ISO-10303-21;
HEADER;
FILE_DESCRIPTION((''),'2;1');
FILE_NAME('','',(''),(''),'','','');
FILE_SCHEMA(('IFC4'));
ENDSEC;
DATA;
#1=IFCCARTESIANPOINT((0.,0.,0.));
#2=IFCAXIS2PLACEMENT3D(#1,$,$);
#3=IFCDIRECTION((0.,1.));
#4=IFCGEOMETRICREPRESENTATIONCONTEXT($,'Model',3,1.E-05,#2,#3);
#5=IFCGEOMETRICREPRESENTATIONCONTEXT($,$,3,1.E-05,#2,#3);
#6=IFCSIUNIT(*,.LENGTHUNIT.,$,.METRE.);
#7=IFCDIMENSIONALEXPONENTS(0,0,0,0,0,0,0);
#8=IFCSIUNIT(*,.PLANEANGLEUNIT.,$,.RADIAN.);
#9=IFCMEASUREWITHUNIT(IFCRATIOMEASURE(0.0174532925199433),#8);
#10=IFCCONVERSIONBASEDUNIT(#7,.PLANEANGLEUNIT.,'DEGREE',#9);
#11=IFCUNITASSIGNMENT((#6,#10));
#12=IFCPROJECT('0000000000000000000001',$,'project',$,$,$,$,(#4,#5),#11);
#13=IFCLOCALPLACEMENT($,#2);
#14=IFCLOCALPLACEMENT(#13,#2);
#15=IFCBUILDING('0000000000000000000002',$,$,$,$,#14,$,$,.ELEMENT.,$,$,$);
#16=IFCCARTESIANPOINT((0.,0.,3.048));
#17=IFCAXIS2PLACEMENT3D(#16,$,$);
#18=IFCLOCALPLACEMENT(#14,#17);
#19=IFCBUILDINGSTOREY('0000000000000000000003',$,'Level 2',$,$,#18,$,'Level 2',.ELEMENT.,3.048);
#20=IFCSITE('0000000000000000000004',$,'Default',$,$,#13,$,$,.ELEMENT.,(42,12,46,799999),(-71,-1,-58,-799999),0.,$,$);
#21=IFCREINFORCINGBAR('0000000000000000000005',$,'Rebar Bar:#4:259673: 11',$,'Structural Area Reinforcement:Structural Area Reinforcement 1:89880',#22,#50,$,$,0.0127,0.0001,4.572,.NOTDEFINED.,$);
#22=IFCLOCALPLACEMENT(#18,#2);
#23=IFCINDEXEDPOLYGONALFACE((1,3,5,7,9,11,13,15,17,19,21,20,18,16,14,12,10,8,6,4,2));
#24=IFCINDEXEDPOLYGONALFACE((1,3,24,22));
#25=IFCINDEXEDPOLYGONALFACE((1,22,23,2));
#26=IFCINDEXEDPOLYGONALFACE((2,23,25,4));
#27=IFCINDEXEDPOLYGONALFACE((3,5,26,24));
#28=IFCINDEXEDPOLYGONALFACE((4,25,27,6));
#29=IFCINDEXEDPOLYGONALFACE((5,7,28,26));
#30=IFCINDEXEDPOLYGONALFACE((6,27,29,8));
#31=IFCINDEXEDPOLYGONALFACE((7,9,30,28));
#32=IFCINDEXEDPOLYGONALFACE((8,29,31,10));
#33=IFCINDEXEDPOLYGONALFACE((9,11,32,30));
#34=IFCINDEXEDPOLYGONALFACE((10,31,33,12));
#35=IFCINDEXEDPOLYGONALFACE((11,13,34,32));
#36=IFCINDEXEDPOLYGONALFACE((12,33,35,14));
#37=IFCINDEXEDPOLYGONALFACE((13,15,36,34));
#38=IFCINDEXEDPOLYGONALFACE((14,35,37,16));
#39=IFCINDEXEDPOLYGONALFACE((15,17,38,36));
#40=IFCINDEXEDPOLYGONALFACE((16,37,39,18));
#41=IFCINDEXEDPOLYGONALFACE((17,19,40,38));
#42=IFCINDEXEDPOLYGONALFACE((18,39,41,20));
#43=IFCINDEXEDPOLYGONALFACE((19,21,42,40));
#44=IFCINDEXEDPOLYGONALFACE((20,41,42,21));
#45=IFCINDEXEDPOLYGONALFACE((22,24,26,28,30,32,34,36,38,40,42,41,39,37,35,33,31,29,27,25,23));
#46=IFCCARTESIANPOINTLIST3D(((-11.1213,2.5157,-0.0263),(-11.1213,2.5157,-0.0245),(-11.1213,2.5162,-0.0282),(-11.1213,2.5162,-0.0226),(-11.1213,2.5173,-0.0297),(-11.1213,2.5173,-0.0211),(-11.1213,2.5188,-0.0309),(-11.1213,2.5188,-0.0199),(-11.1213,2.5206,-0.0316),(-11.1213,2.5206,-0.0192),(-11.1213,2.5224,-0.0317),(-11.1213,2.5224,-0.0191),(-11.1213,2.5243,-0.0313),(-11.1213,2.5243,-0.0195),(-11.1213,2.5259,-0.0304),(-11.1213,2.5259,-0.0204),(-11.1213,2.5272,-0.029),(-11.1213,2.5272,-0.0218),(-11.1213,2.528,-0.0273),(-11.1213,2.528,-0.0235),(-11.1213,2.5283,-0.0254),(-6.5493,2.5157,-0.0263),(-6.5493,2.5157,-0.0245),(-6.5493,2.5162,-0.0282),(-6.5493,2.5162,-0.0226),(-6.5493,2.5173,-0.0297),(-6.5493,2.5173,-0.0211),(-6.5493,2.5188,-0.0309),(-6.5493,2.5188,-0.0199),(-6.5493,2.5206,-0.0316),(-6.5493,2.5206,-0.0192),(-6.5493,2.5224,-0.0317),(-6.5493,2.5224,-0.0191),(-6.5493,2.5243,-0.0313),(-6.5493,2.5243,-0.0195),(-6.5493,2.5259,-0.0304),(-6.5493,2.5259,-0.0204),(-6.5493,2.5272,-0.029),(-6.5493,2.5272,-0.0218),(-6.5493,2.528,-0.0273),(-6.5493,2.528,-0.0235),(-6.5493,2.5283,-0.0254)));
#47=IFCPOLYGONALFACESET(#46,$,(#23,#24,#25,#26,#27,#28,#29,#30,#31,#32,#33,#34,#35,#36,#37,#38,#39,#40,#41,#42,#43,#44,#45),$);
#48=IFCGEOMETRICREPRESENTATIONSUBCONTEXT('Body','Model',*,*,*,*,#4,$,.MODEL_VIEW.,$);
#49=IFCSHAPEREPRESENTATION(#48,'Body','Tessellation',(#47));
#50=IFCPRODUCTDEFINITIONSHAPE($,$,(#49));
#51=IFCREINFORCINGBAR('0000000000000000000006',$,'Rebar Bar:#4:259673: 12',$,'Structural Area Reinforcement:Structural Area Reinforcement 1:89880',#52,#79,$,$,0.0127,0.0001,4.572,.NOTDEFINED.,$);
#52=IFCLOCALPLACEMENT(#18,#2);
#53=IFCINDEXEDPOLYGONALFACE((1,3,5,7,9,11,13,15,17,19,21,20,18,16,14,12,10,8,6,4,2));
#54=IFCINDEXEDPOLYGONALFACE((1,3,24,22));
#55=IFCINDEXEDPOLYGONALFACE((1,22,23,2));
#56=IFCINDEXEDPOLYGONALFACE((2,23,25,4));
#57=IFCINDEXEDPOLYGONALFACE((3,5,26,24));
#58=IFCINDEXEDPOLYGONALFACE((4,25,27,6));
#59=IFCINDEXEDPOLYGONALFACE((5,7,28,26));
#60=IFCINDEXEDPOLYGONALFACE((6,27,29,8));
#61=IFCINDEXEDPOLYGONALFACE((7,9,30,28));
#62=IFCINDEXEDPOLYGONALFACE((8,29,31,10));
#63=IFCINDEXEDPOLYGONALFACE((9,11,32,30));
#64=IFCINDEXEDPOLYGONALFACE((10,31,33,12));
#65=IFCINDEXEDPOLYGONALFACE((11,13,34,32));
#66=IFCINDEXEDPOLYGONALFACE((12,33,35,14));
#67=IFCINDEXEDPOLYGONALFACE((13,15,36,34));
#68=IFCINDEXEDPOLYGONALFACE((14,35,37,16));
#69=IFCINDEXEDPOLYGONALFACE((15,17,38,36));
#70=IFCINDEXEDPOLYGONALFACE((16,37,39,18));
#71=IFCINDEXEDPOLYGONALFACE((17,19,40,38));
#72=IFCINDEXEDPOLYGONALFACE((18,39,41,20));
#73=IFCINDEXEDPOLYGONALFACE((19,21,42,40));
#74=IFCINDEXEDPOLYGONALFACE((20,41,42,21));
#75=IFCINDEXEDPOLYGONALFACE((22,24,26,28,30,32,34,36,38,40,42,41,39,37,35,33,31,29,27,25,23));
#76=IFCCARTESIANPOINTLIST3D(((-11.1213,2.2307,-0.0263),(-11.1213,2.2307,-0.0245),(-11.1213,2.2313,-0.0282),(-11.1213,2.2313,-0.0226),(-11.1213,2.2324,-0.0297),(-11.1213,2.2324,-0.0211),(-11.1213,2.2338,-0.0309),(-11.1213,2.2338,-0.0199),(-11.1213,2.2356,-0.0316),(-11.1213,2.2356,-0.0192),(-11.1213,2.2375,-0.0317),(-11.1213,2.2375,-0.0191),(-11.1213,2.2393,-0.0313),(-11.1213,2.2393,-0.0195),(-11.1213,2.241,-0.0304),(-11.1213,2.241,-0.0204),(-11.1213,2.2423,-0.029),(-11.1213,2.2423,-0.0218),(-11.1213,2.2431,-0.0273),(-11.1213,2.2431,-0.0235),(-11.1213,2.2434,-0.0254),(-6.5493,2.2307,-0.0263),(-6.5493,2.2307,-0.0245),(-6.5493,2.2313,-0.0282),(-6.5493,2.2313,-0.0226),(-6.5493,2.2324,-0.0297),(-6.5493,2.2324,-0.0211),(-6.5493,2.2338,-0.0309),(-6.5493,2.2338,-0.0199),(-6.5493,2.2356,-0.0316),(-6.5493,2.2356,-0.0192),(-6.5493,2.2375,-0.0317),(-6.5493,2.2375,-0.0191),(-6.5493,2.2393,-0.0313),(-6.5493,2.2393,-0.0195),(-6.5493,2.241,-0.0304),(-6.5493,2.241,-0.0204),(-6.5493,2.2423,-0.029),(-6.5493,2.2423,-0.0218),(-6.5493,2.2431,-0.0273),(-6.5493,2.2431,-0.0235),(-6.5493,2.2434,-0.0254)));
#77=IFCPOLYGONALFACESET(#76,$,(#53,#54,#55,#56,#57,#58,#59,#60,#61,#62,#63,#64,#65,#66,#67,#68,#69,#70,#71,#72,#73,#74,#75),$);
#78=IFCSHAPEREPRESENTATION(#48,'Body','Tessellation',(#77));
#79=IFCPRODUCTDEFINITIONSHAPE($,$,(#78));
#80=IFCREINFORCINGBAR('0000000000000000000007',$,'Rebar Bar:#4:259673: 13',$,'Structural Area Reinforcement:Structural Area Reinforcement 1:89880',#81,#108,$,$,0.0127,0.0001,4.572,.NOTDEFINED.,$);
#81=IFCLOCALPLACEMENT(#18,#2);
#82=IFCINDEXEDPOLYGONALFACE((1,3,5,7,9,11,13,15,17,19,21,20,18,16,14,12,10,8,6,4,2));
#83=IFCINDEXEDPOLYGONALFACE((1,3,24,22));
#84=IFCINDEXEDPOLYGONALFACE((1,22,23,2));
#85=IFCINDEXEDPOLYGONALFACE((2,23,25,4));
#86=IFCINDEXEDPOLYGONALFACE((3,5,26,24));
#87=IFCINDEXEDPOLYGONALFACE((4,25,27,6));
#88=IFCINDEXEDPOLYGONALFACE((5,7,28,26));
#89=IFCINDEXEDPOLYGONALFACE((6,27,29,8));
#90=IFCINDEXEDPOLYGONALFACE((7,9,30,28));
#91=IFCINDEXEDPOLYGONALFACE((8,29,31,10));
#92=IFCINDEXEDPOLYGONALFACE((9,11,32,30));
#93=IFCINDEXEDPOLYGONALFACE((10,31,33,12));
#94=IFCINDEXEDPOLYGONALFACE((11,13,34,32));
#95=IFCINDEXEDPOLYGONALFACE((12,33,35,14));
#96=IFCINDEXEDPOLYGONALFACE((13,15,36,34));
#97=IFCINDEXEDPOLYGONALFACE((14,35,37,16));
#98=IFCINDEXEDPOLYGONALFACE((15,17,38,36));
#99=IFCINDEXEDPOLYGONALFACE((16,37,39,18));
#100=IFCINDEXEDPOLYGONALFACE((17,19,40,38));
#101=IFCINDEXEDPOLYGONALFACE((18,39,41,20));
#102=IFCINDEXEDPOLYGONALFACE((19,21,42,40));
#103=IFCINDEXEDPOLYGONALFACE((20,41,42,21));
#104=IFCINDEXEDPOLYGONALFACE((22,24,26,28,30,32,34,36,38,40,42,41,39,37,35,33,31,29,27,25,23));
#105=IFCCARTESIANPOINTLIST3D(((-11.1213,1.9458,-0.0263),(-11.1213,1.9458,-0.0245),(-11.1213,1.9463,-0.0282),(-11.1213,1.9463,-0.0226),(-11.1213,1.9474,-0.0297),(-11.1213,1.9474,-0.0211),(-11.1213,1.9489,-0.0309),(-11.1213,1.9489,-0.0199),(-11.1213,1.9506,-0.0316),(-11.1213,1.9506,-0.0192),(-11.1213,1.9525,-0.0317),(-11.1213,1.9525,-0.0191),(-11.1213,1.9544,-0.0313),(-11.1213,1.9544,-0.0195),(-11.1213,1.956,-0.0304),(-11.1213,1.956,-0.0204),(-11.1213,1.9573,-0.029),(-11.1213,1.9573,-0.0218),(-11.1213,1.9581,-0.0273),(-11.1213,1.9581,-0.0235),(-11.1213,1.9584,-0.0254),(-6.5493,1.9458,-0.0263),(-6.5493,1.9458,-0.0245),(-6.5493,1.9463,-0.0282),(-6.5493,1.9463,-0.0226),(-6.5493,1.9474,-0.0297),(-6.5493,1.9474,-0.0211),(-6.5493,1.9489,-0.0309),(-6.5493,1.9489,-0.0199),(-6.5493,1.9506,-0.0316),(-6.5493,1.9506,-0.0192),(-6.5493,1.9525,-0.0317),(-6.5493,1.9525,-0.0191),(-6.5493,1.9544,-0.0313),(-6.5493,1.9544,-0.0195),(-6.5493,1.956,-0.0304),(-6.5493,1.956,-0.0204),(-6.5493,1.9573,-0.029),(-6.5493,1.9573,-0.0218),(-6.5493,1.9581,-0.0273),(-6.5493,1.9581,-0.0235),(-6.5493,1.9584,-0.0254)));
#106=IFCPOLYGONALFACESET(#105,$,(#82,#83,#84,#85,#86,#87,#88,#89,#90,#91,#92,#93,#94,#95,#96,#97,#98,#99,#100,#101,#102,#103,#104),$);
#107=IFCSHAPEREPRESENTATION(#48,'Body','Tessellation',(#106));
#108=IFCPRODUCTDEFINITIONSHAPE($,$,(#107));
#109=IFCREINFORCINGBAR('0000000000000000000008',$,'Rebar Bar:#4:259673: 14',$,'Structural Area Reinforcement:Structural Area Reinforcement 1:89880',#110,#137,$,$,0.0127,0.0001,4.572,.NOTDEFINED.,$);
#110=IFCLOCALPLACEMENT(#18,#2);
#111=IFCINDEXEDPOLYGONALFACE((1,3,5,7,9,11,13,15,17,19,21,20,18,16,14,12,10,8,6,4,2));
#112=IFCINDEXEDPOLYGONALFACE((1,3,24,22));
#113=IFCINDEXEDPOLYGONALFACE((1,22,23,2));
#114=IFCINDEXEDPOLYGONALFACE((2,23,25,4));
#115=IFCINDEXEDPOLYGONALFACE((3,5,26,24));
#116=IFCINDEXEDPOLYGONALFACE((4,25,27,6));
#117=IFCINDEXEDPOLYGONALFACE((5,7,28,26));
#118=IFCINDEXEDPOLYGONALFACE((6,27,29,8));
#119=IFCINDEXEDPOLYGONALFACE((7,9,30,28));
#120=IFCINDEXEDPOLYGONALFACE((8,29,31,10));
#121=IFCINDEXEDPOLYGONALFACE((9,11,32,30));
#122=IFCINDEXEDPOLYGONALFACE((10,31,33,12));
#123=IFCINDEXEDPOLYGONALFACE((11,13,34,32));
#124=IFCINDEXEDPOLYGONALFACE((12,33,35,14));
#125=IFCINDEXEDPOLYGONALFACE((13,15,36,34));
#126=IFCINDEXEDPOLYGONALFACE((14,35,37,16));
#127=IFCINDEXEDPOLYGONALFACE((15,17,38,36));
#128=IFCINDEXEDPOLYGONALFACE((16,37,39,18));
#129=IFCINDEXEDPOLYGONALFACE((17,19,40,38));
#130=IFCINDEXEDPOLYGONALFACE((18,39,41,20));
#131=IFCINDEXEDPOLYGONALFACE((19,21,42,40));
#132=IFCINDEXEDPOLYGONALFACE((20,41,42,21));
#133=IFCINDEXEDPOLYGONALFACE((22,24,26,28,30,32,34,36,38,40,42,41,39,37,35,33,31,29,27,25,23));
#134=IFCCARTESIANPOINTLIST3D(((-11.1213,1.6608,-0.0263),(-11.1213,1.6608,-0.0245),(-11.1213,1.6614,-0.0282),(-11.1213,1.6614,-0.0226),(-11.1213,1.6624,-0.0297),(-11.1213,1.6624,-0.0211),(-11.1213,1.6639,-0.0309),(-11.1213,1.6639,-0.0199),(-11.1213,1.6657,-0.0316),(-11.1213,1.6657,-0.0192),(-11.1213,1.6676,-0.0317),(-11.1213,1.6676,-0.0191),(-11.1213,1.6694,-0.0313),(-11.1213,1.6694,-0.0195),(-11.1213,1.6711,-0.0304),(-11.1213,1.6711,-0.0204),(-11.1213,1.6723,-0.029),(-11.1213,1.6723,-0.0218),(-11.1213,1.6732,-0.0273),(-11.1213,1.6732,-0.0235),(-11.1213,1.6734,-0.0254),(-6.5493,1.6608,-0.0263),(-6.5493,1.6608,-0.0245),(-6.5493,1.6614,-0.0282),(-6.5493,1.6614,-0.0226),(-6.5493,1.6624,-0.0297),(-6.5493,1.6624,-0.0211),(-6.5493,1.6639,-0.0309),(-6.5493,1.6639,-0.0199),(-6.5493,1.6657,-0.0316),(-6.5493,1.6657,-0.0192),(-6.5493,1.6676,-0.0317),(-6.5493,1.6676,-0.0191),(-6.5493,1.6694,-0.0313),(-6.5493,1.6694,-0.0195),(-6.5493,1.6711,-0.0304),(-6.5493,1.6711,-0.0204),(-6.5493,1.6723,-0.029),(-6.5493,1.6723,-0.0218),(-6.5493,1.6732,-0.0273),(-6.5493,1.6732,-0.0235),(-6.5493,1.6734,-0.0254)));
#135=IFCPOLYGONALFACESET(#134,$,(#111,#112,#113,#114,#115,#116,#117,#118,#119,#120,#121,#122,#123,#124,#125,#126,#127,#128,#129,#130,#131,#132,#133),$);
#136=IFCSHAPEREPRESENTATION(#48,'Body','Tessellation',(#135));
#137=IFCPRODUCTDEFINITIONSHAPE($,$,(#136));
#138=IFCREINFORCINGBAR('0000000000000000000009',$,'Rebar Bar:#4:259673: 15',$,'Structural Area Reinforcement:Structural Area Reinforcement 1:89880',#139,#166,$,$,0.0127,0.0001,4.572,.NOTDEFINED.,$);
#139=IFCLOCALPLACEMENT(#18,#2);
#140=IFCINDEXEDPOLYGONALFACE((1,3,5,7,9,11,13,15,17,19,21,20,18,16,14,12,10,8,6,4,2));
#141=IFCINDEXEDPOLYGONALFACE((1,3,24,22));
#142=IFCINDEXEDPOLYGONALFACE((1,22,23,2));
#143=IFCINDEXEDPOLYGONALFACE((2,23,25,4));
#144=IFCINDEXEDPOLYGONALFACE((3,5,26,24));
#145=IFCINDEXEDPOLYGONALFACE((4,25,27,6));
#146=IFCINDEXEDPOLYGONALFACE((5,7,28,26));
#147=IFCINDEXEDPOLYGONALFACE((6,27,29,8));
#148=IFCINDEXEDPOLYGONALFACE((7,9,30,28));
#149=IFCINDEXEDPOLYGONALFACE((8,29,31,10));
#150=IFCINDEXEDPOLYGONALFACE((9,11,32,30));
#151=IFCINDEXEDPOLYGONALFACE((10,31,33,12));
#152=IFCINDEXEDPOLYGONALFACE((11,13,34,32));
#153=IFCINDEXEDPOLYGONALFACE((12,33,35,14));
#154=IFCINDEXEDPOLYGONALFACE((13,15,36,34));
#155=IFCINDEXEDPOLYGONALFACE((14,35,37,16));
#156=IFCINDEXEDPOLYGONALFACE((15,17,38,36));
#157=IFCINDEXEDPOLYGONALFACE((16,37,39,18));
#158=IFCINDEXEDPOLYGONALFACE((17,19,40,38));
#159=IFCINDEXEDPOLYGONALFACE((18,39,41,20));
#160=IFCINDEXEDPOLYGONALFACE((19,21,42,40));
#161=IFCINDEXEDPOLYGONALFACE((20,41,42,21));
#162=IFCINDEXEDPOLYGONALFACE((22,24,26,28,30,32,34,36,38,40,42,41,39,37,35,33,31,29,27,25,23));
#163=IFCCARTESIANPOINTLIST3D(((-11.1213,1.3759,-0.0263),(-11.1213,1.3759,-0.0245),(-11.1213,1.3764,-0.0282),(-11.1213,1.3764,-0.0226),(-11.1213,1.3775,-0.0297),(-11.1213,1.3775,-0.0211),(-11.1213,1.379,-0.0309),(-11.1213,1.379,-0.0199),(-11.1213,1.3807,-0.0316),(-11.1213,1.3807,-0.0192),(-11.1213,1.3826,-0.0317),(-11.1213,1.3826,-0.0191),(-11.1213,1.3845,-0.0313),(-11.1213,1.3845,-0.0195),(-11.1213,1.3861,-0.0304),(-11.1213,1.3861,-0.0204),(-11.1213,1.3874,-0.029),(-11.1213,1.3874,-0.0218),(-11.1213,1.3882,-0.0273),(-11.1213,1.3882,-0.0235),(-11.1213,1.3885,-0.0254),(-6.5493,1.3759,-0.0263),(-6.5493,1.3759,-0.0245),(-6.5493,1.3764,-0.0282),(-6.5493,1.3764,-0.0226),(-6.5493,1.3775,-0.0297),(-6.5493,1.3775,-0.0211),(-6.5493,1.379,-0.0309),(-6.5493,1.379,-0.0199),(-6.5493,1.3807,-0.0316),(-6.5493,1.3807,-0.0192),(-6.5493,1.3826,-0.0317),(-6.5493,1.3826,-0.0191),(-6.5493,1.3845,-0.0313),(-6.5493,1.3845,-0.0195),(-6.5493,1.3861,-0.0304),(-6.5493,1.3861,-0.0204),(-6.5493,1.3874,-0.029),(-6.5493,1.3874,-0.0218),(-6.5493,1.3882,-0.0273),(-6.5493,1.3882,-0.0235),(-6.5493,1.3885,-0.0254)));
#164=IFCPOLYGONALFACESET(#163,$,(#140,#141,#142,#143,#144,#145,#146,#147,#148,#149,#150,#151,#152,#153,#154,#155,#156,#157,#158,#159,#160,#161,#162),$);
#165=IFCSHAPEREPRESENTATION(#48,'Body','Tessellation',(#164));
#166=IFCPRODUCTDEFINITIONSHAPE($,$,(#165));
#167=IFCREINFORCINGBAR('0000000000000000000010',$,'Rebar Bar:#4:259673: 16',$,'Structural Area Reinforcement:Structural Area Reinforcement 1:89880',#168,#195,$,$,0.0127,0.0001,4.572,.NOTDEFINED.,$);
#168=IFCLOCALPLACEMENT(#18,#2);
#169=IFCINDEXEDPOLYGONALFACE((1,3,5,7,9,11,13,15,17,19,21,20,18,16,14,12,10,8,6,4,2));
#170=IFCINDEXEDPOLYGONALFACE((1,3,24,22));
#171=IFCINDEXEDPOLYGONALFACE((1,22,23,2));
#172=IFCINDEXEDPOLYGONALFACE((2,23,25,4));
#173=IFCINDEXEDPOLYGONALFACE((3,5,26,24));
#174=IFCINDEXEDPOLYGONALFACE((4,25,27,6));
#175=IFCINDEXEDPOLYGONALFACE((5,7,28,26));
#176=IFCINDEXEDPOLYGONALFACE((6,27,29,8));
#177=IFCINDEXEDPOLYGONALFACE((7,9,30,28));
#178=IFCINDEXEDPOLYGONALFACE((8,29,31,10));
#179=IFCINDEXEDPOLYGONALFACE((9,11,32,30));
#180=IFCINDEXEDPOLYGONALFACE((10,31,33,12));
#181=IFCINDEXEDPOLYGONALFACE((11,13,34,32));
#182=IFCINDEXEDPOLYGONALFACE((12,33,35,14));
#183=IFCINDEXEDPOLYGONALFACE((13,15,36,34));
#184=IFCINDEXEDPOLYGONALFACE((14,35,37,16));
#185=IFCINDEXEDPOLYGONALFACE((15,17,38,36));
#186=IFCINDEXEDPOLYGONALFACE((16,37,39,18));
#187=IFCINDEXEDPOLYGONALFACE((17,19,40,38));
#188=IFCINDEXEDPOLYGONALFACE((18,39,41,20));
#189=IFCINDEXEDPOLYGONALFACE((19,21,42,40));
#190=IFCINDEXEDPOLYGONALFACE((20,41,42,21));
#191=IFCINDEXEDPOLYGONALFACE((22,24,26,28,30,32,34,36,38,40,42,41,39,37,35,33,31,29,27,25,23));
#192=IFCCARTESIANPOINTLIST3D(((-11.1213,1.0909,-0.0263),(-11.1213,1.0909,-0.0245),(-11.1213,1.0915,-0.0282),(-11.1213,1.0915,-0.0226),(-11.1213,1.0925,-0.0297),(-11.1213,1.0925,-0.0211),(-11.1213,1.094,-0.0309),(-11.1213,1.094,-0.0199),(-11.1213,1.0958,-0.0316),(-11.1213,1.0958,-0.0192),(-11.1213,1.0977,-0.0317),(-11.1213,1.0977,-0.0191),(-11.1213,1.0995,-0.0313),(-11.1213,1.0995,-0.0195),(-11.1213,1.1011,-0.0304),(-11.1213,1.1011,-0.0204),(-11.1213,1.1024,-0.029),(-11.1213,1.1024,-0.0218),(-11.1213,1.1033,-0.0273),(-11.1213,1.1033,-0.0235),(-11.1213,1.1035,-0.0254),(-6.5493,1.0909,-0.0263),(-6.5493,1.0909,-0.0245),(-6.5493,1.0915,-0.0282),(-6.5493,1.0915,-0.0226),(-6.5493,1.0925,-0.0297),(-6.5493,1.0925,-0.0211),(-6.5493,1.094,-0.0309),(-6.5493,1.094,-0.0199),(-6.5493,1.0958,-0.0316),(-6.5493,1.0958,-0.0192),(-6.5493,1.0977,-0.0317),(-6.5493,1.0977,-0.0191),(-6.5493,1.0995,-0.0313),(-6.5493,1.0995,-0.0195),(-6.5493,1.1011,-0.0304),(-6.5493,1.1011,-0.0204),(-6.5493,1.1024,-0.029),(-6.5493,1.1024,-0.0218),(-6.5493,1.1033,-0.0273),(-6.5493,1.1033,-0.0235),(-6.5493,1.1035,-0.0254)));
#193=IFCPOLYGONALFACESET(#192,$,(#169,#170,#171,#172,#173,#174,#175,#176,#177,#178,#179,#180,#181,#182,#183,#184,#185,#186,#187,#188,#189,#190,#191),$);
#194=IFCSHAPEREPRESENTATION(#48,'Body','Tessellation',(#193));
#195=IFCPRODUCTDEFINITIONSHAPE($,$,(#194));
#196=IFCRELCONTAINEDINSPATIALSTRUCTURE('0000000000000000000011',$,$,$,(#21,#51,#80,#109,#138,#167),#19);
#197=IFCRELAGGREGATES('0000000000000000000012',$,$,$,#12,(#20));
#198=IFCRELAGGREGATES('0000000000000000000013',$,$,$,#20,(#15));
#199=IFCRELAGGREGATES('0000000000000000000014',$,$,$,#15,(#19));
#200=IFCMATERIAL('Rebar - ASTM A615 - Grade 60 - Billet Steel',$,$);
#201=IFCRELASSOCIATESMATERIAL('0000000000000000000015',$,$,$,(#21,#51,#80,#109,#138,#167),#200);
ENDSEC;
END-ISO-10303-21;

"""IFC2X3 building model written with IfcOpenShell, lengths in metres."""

from ifc_helpers import new_model, entity, si_unit, converted_unit, direction, frame, origin, place, context, subcontext, project, spatial, material, element, save


model = new_model("IFC2X3")

# Units and contexts
model_context = context("Model", 3, precision=1e-05, world=origin(), true_north=direction((0.0, 1.0)))
context_of_model = context(None, 3, precision=1e-05, world=origin(), true_north=direction((0.0, 1.0)))
body_context = subcontext(model_context, "Body", "Model", "MODEL_VIEW")
ifc_project = project(units=[si_unit("LENGTHUNIT", "METRE"), converted_unit("PLANEANGLEUNIT", "DEGREE", entity("IfcRatioMeasure", 0.0174532925199433), si_unit("PLANEANGLEUNIT", "RADIAN"), dimensions=[0, 0, 0, 0, 0, 0, 0])], contexts=[model_context, context_of_model])

# Site, building, storey
site_placement = place(None, origin())
site = spatial("IfcSite", under=ifc_project, at=site_placement, Name="Default", CompositionType="ELEMENT", RefLatitude=(42, 12, 46, 799999), RefLongitude=(-71, -1, -58, -799999), RefElevation=0.0)
building_placement = place(site_placement, origin())
building = spatial("IfcBuilding", under=site, at=building_placement, CompositionType="ELEMENT")
storey_placement = place(building_placement, frame((0.0, 0.0, 3.048)))
storey = spatial("IfcBuildingStorey", under=building, at=storey_placement, Name="Level 2", LongName="Level 2", CompositionType="ELEMENT", Elevation=3.048)

# Reinforcing bars
ifc_material_1 = material(Name="Rebar - ASTM A615 - Grade 60 - Billet Steel")
reinforcing_bar_1_placement = place(storey_placement, origin())
element("IfcReinforcingBar", 1, at=reinforcing_bar_1_placement, inside=storey, material=ifc_material_1, Name="Rebar Bar:#4:259673: 11", ObjectType="Structural Area Reinforcement:Structural Area Reinforcement 1:89880", BarLength=4.572, BarRole="NOTDEFINED", CrossSectionArea=0.0001, NominalDiameter=0.0127, context=body_context, shape_type="AdvancedSweptSolid", body=[
    entity("IfcSweptDiskSolid", entity("IfcCompositeCurve", [entity("IfcCompositeCurveSegment", "CONTINUOUS", True, entity("IfcPolyline", [entity("IfcCartesianPoint", [-11.1213, 2.522, -0.0254]), entity("IfcCartesianPoint", [-6.5493, 2.522, -0.0254])]))], False), 0.0063, None, 0.0, 1.0),
])
reinforcing_bar_2_placement = place(storey_placement, origin())
element("IfcReinforcingBar", 2, at=reinforcing_bar_2_placement, inside=storey, material=ifc_material_1, Name="Rebar Bar:#4:259673: 12", ObjectType="Structural Area Reinforcement:Structural Area Reinforcement 1:89880", BarLength=4.572, BarRole="NOTDEFINED", CrossSectionArea=0.0001, NominalDiameter=0.0127, context=body_context, shape_type="AdvancedSweptSolid", body=[
    entity("IfcSweptDiskSolid", entity("IfcCompositeCurve", [entity("IfcCompositeCurveSegment", "CONTINUOUS", True, entity("IfcPolyline", [entity("IfcCartesianPoint", [-11.1213, 2.237, -0.0254]), entity("IfcCartesianPoint", [-6.5493, 2.237, -0.0254])]))], False), 0.0063, None, 0.0, 1.0),
])
reinforcing_bar_3_placement = place(storey_placement, origin())
element("IfcReinforcingBar", 3, at=reinforcing_bar_3_placement, inside=storey, material=ifc_material_1, Name="Rebar Bar:#4:259673: 13", ObjectType="Structural Area Reinforcement:Structural Area Reinforcement 1:89880", BarLength=4.572, BarRole="NOTDEFINED", CrossSectionArea=0.0001, NominalDiameter=0.0127, context=body_context, shape_type="AdvancedSweptSolid", body=[
    entity("IfcSweptDiskSolid", entity("IfcCompositeCurve", [entity("IfcCompositeCurveSegment", "CONTINUOUS", True, entity("IfcPolyline", [entity("IfcCartesianPoint", [-11.1213, 1.9521, -0.0254]), entity("IfcCartesianPoint", [-6.5493, 1.9521, -0.0254])]))], False), 0.0063, None, 0.0, 1.0),
])
reinforcing_bar_4_placement = place(storey_placement, origin())
element("IfcReinforcingBar", 4, at=reinforcing_bar_4_placement, inside=storey, material=ifc_material_1, Name="Rebar Bar:#4:259673: 14", ObjectType="Structural Area Reinforcement:Structural Area Reinforcement 1:89880", BarLength=4.572, BarRole="NOTDEFINED", CrossSectionArea=0.0001, NominalDiameter=0.0127, context=body_context, shape_type="AdvancedSweptSolid", body=[
    entity("IfcSweptDiskSolid", entity("IfcCompositeCurve", [entity("IfcCompositeCurveSegment", "CONTINUOUS", True, entity("IfcPolyline", [entity("IfcCartesianPoint", [-11.1213, 1.6671, -0.0254]), entity("IfcCartesianPoint", [-6.5493, 1.6671, -0.0254])]))], False), 0.0063, None, 0.0, 1.0),
])
reinforcing_bar_5_placement = place(storey_placement, origin())
element("IfcReinforcingBar", 5, at=reinforcing_bar_5_placement, inside=storey, material=ifc_material_1, Name="Rebar Bar:#4:259673: 15", ObjectType="Structural Area Reinforcement:Structural Area Reinforcement 1:89880", BarLength=4.572, BarRole="NOTDEFINED", CrossSectionArea=0.0001, NominalDiameter=0.0127, context=body_context, shape_type="AdvancedSweptSolid", body=[
    entity("IfcSweptDiskSolid", entity("IfcCompositeCurve", [entity("IfcCompositeCurveSegment", "CONTINUOUS", True, entity("IfcPolyline", [entity("IfcCartesianPoint", [-11.1213, 1.3821, -0.0254]), entity("IfcCartesianPoint", [-6.5493, 1.3821, -0.0254])]))], False), 0.0063, None, 0.0, 1.0),
])
reinforcing_bar_6_placement = place(storey_placement, origin())
element("IfcReinforcingBar", 6, at=reinforcing_bar_6_placement, inside=storey, material=ifc_material_1, Name="Rebar Bar:#4:259673: 16", ObjectType="Structural Area Reinforcement:Structural Area Reinforcement 1:89880", BarLength=4.572, BarRole="NOTDEFINED", CrossSectionArea=0.0001, NominalDiameter=0.0127, context=body_context, shape_type="AdvancedSweptSolid", body=[
    entity("IfcSweptDiskSolid", entity("IfcCompositeCurve", [entity("IfcCompositeCurveSegment", "CONTINUOUS", True, entity("IfcPolyline", [entity("IfcCartesianPoint", [-11.1213, 1.0972, -0.0254]), entity("IfcCartesianPoint", [-6.5493, 1.0972, -0.0254])]))], False), 0.0063, None, 0.0, 1.0),
])

save(model, "model.ifc")
